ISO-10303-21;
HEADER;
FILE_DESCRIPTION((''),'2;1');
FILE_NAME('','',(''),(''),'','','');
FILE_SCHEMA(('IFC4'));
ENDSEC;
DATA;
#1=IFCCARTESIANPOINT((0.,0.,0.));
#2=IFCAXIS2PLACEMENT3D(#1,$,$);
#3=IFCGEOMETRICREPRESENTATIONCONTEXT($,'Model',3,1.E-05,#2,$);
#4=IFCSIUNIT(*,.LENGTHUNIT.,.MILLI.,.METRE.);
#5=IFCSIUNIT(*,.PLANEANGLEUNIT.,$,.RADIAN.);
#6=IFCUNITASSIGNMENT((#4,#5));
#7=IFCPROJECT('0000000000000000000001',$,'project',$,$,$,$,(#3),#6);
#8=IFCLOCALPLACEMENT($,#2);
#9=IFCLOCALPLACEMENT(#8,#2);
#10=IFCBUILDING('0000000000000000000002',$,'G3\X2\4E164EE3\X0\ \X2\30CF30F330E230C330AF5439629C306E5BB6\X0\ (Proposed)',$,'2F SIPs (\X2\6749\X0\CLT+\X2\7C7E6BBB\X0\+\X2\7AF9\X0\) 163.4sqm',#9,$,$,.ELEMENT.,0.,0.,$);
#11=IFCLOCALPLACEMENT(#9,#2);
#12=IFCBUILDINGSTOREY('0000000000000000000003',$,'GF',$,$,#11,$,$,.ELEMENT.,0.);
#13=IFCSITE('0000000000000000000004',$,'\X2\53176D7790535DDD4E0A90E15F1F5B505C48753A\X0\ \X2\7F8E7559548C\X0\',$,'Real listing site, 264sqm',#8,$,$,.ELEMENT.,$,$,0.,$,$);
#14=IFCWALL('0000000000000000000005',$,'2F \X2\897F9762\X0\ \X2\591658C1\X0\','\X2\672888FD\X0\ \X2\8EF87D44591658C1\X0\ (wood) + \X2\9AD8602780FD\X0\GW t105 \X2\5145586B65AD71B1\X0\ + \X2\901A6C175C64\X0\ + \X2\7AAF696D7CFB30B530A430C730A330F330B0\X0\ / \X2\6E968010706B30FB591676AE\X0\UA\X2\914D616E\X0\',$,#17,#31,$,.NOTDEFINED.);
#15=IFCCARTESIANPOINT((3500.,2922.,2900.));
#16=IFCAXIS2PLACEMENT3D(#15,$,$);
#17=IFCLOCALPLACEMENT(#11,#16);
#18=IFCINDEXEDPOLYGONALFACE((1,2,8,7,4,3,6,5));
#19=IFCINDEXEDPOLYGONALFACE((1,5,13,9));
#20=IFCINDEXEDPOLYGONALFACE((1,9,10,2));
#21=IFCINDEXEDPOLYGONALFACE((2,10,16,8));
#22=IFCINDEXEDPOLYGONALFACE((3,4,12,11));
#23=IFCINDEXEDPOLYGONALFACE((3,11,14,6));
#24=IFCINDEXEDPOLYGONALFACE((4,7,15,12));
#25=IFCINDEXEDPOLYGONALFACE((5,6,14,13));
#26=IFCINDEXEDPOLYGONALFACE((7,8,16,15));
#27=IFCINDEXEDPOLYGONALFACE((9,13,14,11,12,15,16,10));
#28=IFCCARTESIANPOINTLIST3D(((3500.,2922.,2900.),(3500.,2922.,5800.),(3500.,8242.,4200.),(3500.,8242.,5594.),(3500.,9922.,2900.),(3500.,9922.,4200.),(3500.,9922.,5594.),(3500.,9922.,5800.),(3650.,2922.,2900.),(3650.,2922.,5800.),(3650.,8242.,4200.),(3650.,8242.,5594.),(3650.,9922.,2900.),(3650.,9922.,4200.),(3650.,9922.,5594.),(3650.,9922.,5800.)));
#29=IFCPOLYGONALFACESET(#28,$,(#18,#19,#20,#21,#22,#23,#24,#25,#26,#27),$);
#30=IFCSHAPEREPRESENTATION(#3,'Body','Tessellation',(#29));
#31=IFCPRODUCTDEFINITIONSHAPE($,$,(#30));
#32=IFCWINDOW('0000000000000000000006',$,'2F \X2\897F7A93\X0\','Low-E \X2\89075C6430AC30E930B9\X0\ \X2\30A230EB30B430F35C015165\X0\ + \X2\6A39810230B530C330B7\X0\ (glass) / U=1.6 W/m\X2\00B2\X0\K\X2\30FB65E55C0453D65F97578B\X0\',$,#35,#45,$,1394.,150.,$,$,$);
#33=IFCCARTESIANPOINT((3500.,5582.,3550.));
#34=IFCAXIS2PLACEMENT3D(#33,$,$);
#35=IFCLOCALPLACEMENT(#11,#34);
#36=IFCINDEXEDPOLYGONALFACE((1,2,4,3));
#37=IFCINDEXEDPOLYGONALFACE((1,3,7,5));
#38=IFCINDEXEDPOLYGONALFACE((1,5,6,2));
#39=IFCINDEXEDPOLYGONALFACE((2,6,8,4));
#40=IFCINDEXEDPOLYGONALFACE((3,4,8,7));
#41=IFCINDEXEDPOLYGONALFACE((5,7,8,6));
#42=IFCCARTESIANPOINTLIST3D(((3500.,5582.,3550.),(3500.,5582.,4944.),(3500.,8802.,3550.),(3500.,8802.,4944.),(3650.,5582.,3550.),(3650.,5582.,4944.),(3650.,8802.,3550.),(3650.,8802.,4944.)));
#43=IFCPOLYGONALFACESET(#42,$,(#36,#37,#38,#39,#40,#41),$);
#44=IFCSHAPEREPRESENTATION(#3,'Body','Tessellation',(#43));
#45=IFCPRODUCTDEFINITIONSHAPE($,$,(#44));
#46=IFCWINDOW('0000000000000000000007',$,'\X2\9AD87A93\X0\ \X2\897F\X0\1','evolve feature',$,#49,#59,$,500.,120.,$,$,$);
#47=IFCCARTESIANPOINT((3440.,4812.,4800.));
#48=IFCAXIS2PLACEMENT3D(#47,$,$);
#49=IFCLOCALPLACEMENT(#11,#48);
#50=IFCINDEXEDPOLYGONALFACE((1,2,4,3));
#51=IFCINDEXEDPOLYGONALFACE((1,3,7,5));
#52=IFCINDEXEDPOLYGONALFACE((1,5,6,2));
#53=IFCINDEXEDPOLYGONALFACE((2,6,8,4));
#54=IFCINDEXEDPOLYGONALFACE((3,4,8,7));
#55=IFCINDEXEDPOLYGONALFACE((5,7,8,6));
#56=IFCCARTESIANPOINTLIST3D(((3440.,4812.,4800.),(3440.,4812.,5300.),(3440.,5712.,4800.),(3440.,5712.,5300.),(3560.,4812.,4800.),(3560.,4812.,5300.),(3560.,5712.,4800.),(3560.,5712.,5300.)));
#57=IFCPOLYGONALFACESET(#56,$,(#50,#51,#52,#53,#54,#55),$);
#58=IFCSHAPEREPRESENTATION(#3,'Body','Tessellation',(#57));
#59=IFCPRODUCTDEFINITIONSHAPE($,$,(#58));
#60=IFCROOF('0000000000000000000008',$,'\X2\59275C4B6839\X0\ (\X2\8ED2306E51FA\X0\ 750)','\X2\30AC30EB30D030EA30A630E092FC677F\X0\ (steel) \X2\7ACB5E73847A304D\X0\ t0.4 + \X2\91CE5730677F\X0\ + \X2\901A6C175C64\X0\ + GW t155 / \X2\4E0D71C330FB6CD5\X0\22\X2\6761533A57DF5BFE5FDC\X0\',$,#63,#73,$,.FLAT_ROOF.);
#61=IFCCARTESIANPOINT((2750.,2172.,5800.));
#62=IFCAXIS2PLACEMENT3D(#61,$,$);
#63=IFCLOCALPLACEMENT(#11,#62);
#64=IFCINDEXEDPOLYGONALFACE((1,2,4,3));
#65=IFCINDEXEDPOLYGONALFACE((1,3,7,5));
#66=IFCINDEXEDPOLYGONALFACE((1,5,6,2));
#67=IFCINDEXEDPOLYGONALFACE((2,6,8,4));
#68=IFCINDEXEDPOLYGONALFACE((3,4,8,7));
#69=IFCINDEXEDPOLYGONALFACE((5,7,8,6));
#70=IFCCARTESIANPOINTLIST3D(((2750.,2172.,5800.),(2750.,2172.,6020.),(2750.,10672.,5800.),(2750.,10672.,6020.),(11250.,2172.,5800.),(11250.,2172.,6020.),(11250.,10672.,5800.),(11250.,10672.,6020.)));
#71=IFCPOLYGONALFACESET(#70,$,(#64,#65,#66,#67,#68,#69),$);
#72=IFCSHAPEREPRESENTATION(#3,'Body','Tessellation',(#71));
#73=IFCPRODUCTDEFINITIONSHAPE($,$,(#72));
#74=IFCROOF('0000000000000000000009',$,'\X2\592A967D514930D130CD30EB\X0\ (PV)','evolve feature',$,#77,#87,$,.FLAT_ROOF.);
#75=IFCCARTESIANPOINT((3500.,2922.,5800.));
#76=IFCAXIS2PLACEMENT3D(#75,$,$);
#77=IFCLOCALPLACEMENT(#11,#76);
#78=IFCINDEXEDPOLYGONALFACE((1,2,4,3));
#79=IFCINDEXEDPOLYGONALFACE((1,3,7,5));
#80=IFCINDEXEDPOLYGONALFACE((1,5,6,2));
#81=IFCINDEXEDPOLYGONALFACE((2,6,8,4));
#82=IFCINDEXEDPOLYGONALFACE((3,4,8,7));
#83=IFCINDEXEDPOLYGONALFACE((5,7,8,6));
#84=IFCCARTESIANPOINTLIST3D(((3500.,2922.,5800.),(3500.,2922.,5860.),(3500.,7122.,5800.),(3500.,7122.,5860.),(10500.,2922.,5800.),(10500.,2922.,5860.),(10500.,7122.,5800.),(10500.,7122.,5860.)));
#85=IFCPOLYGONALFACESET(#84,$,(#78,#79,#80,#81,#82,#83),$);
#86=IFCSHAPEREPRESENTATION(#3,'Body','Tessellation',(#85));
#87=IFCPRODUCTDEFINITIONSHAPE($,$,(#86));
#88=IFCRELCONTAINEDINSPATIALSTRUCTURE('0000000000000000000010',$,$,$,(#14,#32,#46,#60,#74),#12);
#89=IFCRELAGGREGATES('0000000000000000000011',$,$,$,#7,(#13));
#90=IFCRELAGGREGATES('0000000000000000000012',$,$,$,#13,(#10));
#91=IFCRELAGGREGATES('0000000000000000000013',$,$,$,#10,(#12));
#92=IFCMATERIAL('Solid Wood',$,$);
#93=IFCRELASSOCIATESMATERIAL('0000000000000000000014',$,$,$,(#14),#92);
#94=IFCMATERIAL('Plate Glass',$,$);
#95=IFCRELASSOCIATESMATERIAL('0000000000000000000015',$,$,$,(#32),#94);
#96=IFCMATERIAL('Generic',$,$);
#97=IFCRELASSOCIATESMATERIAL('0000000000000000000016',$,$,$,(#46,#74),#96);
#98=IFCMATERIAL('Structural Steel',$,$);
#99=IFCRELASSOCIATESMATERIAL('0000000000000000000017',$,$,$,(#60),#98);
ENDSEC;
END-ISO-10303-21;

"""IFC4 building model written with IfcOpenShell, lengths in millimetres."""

from ifc_helpers import new_model, si_unit, frame, frame_2d, origin, place, context, project, spatial, rectangle, extrude, material, element, fill, save


model = new_model("IFC4")

# Units and contexts
model_context = context("Model", 3, precision=1e-05, world=origin())
ifc_project = project(units=[si_unit("LENGTHUNIT", "METRE", prefix="MILLI"), si_unit("PLANEANGLEUNIT", "RADIAN")], contexts=[model_context])

# Site, building, storey
site_placement = place(None, origin())
site = spatial("IfcSite", under=ifc_project, at=site_placement, Name="北海道川上郡弟子屈町 美留和", ObjectType="Real listing site, 264sqm", CompositionType="ELEMENT", RefElevation=0.0)
building_placement = place(site_placement, origin())
building = spatial("IfcBuilding", under=site, at=building_placement, Name="G3世代 ハンモック吹抜の家 (Proposed)", ObjectType="2F SIPs (杉CLT+籾殻+竹) 163.4sqm", CompositionType="ELEMENT", ElevationOfRefHeight=0.0, ElevationOfTerrain=0.0)
storey_placement = place(building_placement, origin())
storey = spatial("IfcBuildingStorey", under=building, at=storey_placement, Name="GF", CompositionType="ELEMENT", Elevation=0.0)

# Shared definitions
ifc_material_1 = material(Name="Solid Wood")
ifc_material_2 = material(Name="Generic")

# Shared definitions
ifc_material_3 = material(Name="Plate Glass")

# Wall, openings, windows
wall_1_placement = place(storey_placement, frame((3500.0, 2922.0, 2900.0)))
wall_1 = element("IfcWall", 1, at=wall_1_placement, inside=storey, material=ifc_material_1, Name="2F 西面 外壁", Description="木製 軸組外壁 (wood) + 高性能GW t105 充填断熱 + 通気層 + 窯業系サイディング / 準耐火・外皮UA配慮", PredefinedType="NOTDEFINED", context=model_context, shape_type="SweptSolid", body=[
    extrude(rectangle(XDim=150.0, YDim=7000.0, at=frame_2d((75.0, 3500.0))), frame((3500.0, 2922.0, 2900.0)), (0.0, 0.0, 1.0), 2900.0),
])
opening_1_placement = place(storey_placement, frame((3500.0, 5582.0, 3550.0)))
opening_1 = element("IfcOpeningElement", 2, at=opening_1_placement, cuts=wall_1, PredefinedType="NOTDEFINED", context=model_context, shape_type="SweptSolid", body=[
    extrude(rectangle(XDim=150.0, YDim=3220.0, at=frame_2d((75.0, 1610.0))), frame((3500.0, 5582.0, 3550.0)), (0.0, 0.0, 1.0), 1394.0),
])
opening_2_placement = place(storey_placement, frame((3440.0, 4812.0, 4800.0)))
opening_2 = element("IfcOpeningElement", 3, at=opening_2_placement, cuts=wall_1, PredefinedType="NOTDEFINED", context=model_context, shape_type="SweptSolid", body=[
    extrude(rectangle(XDim=120.0, YDim=900.0, at=frame_2d((60.0, 450.0))), frame((3440.0, 4812.0, 4800.0)), (0.0, 0.0, 1.0), 500.0),
])
window_1_placement = place(storey_placement, frame((3500.0, 5582.0, 3550.0)))
window_1 = element("IfcWindow", 4, at=window_1_placement, inside=storey, material=ifc_material_3, Name="2F 西窓", Description="Low-E 複層ガラス アルゴン封入 + 樹脂サッシ (glass) / U=1.6 W/m²K・日射取得型", OverallHeight=1394.0, OverallWidth=150.0, context=model_context, shape_type="SweptSolid", body=[
    extrude(rectangle(XDim=150.0, YDim=3220.0, at=frame_2d((75.0, 1610.0))), frame((3500.0, 5582.0, 3550.0)), (0.0, 0.0, 1.0), 1394.0),
])
fill(opening_1, window_1)
window_2_placement = place(storey_placement, frame((3440.0, 4812.0, 4800.0)))
window_2 = element("IfcWindow", 5, at=window_2_placement, inside=storey, material=ifc_material_2, Name="高窓 西1", Description="evolve feature", OverallHeight=500.0, OverallWidth=120.0, context=model_context, shape_type="SweptSolid", body=[
    extrude(rectangle(XDim=120.0, YDim=900.0, at=frame_2d((60.0, 450.0))), frame((3440.0, 4812.0, 4800.0)), (0.0, 0.0, 1.0), 500.0),
])
fill(opening_2, window_2)

# Roofs
ifc_material_4 = material(Name="Structural Steel")
roof_1_placement = place(storey_placement, frame((2750.0, 2172.0, 5800.0)))
element("IfcRoof", 6, at=roof_1_placement, inside=storey, material=ifc_material_4, Name="大屋根 (軒の出 750)", Description="ガルバリウム鋼板 (steel) 立平葺き t0.4 + 野地板 + 通気層 + GW t155 / 不燃・法22条区域対応", PredefinedType="FLAT_ROOF", context=model_context, shape_type="SweptSolid", body=[
    extrude(rectangle(XDim=8500.0, YDim=8500.0, at=frame_2d((4250.0, 4250.0))), frame((2750.0, 2172.0, 5800.0)), (0.0, 0.0, 1.0), 220.0),
])
roof_2_placement = place(storey_placement, frame((3500.0, 2922.0, 5800.0)))
element("IfcRoof", 7, at=roof_2_placement, inside=storey, material=ifc_material_2, Name="太陽光パネル (PV)", Description="evolve feature", PredefinedType="FLAT_ROOF", context=model_context, shape_type="SweptSolid", body=[
    extrude(rectangle(XDim=7000.0, YDim=4200.0, at=frame_2d((3500.0, 2100.0))), frame((3500.0, 2922.0, 5800.0)), (0.0, 0.0, 1.0), 60.0),
])

save(model, "model.ifc")
